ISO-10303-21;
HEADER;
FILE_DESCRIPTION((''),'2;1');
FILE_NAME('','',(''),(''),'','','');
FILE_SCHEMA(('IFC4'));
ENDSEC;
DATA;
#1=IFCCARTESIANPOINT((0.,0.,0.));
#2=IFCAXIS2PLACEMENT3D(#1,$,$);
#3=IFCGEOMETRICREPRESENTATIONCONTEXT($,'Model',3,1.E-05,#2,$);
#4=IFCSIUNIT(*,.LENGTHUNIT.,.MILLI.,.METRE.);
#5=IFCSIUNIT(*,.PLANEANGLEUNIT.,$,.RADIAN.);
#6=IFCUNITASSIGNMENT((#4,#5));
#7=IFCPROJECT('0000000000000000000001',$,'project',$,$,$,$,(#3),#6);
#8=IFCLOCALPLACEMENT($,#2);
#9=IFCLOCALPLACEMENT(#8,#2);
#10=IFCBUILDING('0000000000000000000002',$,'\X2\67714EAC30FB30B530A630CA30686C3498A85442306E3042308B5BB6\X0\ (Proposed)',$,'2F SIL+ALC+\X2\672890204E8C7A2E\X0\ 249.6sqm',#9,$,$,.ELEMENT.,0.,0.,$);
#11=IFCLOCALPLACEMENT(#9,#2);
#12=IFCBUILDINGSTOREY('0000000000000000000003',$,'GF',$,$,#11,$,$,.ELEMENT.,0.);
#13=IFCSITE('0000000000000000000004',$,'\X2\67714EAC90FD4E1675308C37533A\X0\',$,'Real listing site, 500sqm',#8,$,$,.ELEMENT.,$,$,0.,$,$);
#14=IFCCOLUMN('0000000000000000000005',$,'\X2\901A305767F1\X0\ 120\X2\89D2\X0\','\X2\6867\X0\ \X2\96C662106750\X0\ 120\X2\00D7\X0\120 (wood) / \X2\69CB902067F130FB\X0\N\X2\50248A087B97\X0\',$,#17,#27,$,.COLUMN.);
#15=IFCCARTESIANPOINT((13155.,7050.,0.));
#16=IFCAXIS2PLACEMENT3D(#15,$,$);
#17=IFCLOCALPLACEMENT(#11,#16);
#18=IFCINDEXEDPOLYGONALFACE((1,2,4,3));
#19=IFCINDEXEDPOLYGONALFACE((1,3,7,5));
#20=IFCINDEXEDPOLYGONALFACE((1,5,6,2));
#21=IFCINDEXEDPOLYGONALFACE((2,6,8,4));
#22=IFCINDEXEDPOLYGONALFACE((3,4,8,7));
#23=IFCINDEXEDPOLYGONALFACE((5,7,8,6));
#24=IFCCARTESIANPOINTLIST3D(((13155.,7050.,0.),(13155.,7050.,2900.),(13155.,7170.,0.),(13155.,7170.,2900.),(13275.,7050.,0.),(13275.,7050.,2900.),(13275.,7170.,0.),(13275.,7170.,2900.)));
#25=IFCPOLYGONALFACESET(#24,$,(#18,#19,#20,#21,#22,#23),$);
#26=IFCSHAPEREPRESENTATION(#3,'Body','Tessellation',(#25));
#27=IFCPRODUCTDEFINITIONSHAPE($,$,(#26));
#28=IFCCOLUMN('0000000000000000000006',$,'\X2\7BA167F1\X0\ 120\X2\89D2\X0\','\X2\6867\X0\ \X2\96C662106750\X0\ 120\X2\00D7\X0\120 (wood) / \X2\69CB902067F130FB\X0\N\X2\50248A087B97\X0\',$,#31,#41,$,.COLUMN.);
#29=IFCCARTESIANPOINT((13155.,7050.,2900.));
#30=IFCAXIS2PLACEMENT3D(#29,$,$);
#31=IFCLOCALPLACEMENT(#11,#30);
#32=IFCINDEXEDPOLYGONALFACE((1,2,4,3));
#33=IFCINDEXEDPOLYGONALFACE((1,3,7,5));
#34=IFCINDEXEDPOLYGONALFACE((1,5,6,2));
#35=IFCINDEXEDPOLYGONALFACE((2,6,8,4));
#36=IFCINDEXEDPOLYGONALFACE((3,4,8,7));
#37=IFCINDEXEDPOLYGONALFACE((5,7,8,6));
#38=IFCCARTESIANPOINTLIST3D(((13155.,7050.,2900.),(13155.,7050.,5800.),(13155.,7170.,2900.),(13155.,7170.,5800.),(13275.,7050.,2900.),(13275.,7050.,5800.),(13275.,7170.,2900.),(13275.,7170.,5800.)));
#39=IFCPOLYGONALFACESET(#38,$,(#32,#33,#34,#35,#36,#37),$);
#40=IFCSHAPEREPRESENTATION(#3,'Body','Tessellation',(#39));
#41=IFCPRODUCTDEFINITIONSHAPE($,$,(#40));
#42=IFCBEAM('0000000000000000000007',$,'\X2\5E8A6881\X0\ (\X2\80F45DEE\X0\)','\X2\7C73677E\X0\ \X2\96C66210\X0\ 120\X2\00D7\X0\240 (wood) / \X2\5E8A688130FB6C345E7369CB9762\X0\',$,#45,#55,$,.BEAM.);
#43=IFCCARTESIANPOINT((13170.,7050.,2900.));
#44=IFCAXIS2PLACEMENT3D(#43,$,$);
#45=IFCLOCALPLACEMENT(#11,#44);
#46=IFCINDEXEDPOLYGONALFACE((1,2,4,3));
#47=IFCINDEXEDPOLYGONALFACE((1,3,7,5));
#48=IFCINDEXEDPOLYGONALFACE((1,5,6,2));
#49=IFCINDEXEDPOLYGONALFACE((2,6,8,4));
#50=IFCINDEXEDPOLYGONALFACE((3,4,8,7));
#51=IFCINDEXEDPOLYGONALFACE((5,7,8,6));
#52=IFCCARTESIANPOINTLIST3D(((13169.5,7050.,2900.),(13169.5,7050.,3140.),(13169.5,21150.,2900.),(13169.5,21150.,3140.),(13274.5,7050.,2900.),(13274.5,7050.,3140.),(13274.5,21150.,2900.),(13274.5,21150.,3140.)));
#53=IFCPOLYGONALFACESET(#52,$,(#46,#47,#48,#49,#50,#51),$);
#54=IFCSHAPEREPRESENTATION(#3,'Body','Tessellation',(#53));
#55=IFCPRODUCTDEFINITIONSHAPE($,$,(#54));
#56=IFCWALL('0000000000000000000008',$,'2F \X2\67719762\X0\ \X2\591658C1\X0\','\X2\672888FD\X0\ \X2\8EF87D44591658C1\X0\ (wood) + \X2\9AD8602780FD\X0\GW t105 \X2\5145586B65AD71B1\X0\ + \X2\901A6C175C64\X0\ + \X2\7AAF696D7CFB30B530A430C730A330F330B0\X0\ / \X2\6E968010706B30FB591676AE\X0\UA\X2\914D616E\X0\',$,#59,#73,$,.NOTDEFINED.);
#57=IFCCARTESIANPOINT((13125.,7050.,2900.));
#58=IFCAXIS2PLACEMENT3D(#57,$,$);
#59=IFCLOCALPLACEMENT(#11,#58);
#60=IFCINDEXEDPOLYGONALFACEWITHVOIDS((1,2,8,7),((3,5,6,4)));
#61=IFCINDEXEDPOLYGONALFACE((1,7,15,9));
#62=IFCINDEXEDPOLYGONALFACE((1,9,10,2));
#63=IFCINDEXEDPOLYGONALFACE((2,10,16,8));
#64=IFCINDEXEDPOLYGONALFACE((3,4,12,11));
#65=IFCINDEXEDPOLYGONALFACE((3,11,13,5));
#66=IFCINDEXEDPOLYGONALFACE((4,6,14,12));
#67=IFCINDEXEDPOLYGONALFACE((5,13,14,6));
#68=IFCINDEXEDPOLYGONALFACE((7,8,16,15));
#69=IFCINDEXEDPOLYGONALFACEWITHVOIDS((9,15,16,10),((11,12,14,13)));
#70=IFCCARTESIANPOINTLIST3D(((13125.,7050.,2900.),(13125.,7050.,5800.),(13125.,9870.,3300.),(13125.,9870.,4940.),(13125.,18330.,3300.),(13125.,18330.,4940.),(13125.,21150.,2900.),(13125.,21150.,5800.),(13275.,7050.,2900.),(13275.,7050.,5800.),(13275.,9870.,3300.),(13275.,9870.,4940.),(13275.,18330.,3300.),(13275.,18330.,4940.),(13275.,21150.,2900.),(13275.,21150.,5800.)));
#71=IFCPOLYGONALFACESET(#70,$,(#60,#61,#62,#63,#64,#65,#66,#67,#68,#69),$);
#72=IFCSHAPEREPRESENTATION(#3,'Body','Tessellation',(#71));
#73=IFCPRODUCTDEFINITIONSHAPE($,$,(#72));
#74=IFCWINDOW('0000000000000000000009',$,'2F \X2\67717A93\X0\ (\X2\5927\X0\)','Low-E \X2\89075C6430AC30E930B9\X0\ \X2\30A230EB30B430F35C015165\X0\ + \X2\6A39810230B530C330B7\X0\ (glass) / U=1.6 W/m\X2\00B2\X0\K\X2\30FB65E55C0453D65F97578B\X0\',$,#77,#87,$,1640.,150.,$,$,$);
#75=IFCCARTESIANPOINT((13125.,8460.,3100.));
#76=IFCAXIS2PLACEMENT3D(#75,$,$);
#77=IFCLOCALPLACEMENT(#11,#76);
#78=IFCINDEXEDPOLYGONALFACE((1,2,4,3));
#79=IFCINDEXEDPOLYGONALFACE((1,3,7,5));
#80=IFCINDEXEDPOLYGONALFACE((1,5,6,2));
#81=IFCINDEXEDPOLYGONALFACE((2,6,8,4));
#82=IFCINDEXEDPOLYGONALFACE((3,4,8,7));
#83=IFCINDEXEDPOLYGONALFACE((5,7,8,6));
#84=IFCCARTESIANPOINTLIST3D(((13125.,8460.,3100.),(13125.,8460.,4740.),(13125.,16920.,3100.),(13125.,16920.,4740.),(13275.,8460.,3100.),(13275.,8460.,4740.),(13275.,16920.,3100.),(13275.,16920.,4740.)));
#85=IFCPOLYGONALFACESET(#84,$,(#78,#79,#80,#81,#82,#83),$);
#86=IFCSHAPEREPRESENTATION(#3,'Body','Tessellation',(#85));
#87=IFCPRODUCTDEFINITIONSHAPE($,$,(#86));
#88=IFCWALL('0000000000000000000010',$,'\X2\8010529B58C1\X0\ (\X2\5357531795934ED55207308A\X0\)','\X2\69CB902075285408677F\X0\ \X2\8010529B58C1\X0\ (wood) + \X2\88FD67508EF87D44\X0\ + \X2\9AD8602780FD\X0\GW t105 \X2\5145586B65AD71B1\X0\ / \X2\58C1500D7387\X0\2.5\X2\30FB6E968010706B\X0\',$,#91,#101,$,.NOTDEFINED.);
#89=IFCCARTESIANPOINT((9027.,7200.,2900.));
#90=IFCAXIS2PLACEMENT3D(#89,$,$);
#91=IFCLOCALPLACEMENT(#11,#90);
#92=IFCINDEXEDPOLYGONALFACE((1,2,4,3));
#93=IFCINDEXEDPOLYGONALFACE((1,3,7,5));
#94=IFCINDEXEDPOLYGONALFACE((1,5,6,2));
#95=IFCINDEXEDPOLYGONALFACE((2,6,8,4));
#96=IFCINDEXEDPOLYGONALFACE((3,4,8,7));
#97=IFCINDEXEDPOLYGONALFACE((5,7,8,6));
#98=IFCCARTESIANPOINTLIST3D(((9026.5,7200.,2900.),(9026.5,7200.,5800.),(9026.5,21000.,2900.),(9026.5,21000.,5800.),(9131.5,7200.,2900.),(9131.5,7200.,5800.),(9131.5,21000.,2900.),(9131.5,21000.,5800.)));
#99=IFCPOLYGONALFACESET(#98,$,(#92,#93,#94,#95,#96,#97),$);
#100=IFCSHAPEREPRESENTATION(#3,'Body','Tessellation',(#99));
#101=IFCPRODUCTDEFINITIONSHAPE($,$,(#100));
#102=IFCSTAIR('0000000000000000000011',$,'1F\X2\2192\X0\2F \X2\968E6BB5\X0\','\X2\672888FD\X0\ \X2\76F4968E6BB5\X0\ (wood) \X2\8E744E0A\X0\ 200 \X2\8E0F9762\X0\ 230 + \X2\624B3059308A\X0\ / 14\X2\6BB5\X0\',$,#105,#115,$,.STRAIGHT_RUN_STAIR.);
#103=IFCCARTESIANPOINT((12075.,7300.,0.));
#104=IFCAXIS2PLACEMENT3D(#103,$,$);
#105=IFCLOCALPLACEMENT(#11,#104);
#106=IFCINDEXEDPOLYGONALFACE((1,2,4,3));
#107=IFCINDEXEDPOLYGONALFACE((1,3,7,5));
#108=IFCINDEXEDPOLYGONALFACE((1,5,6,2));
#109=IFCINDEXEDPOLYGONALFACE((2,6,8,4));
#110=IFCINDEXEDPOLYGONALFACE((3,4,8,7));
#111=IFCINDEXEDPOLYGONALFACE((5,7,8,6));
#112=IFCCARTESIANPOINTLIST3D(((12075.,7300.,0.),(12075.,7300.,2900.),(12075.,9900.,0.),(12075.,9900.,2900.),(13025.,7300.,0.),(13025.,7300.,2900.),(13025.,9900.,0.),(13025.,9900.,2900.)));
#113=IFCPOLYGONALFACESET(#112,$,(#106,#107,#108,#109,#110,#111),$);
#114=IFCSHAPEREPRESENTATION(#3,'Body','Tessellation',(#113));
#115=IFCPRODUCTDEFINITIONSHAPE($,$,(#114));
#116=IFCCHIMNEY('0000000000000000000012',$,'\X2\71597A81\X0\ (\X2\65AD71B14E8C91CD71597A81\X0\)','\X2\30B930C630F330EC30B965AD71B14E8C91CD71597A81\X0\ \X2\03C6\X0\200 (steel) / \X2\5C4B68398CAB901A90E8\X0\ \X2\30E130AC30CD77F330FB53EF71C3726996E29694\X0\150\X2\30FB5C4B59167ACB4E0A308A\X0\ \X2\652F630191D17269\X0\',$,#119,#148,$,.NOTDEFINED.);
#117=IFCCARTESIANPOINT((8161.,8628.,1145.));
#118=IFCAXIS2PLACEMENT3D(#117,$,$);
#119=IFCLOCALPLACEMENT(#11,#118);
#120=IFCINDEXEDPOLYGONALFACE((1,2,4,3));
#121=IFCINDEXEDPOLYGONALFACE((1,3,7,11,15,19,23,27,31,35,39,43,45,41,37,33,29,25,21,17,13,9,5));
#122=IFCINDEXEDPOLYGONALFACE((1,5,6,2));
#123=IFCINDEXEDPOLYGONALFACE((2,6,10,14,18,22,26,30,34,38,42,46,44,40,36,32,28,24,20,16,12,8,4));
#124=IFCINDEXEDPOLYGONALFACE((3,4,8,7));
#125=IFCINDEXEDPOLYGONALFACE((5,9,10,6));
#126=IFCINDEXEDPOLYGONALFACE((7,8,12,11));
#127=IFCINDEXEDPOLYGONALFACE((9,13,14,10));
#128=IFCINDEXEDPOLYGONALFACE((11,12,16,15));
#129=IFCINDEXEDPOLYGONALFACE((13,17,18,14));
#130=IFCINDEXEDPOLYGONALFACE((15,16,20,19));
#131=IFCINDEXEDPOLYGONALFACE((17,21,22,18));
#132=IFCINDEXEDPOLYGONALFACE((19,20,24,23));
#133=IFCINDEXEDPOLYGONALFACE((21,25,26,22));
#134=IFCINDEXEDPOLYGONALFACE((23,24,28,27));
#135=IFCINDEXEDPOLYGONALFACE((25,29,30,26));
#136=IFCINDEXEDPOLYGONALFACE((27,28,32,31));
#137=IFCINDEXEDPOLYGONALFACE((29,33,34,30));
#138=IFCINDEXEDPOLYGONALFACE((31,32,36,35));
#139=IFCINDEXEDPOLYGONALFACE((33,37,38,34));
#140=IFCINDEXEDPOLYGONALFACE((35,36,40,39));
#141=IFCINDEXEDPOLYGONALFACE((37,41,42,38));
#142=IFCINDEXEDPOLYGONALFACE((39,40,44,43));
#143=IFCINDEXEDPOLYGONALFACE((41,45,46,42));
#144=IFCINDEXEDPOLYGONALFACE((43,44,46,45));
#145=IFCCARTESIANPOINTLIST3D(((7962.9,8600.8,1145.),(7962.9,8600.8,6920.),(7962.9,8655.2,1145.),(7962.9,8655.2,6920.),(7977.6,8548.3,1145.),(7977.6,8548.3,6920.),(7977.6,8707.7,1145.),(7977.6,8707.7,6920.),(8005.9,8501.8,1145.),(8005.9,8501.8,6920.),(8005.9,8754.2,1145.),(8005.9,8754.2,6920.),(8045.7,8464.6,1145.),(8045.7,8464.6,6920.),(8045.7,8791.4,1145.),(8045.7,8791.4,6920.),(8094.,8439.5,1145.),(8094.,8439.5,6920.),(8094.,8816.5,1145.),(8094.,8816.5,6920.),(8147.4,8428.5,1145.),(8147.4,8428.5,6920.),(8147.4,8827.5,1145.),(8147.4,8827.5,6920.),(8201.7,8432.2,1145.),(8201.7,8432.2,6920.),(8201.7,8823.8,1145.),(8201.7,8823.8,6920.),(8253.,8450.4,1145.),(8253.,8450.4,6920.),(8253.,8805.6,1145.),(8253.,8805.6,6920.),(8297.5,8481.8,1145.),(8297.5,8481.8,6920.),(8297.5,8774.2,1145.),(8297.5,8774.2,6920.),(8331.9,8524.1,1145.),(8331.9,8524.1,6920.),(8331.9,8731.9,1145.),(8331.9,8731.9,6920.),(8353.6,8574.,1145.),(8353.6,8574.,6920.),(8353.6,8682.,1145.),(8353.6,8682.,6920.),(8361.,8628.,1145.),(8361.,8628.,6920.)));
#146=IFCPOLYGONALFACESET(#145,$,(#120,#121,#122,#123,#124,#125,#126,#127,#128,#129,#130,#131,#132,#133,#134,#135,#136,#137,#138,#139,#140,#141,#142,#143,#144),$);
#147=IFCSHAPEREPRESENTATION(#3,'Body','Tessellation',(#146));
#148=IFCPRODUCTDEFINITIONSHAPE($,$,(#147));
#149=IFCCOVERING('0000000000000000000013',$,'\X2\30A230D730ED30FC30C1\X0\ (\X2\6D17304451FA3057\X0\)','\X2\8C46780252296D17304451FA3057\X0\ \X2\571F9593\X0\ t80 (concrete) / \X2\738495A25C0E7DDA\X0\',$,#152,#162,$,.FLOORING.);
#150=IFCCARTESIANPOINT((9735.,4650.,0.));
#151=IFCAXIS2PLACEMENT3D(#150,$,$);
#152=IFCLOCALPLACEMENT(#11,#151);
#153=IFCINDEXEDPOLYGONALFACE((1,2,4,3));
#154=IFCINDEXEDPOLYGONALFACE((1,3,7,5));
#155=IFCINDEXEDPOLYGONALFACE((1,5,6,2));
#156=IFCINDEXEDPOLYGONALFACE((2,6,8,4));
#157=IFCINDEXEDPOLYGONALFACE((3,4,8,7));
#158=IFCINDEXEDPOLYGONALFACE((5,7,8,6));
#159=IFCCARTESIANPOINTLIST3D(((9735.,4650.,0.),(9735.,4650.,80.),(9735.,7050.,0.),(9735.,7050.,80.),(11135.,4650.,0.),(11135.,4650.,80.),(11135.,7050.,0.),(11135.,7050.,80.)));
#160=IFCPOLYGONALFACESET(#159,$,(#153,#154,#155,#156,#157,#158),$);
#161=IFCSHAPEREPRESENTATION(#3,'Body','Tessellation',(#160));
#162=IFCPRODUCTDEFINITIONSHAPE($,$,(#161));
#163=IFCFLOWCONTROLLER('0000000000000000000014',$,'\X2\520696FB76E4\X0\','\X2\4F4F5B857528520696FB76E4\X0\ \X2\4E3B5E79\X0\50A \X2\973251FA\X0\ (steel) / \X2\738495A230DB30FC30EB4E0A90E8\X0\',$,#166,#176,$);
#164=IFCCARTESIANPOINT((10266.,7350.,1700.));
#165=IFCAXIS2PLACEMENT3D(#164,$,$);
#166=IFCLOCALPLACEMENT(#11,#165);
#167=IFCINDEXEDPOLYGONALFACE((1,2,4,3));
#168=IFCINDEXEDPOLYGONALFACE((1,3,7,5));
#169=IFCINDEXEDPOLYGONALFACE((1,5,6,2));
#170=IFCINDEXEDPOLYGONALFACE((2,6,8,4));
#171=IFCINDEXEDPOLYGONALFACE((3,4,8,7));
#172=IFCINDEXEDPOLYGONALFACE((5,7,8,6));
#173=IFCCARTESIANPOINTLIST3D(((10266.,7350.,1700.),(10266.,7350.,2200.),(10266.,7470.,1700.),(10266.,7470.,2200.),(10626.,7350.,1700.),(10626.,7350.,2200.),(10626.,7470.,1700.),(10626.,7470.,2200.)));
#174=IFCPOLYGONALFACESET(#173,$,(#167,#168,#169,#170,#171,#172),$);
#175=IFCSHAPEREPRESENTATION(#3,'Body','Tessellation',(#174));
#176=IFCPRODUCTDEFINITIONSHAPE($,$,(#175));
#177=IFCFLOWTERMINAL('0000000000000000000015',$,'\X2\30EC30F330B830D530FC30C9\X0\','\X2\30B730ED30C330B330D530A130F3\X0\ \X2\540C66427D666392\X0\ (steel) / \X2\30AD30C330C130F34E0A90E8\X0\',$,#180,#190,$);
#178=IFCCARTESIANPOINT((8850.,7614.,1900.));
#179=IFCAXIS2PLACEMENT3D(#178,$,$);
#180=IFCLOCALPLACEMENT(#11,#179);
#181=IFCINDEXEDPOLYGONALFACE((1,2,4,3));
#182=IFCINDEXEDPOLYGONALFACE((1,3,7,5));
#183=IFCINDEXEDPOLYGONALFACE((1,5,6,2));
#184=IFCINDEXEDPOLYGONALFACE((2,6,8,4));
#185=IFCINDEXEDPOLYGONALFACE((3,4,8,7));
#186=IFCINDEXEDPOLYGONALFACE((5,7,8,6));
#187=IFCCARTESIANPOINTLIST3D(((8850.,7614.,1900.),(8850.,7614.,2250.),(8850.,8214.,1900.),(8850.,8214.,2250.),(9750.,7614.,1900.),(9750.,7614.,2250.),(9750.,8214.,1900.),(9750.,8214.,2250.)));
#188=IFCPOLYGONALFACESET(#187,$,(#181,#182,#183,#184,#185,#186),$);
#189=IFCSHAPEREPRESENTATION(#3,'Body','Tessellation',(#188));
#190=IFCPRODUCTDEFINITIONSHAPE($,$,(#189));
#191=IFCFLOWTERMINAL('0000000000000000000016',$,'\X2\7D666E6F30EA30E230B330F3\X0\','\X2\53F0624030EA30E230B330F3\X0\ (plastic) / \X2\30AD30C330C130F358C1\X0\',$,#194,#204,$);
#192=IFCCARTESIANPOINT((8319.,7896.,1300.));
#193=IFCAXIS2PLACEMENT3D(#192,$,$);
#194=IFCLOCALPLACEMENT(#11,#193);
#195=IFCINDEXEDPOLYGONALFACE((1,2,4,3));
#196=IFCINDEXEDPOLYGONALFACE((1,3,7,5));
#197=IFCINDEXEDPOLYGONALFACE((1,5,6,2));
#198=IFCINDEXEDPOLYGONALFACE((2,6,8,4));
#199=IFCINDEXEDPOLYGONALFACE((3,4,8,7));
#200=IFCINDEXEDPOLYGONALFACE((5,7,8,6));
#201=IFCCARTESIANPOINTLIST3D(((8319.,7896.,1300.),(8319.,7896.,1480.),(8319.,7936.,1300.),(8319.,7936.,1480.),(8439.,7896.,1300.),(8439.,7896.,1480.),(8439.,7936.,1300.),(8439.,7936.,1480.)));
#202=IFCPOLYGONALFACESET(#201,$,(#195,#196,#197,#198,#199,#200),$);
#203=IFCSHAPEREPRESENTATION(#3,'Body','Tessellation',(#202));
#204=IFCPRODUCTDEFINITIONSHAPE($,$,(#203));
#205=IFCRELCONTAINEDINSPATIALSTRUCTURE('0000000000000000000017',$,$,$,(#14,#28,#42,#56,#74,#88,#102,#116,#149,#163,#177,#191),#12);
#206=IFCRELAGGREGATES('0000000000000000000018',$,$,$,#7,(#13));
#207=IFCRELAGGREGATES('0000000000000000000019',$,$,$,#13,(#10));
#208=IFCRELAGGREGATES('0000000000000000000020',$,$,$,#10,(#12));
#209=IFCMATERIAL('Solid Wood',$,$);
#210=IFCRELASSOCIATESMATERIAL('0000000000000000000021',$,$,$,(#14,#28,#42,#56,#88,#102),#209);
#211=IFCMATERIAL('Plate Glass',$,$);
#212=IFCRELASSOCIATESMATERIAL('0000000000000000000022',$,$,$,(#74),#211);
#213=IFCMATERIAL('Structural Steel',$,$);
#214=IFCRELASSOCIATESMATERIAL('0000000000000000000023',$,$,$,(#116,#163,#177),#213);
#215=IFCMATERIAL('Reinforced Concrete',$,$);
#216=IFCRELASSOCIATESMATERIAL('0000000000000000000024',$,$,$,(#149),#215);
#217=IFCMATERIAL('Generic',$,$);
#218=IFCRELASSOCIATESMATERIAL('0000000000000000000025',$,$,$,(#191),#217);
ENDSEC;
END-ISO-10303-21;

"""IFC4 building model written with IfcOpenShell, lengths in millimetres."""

from ifc_helpers import new_model, si_unit, frame, frame_2d, origin, origin_2d, place, context, project, spatial, rectangle, circle, extrude, material, element, fill, save


model = new_model("IFC4")

# Units and contexts
model_context = context("Model", 3, precision=1e-05, world=origin())
ifc_project = project(units=[si_unit("LENGTHUNIT", "METRE", prefix="MILLI"), si_unit("PLANEANGLEUNIT", "RADIAN")], contexts=[model_context])

# Site, building, storey
site_placement = place(None, origin())
site = spatial("IfcSite", under=ifc_project, at=site_placement, Name="東京都世田谷区", ObjectType="Real listing site, 500sqm", CompositionType="ELEMENT", RefElevation=0.0)
building_placement = place(site_placement, origin())
building = spatial("IfcBuilding", under=site, at=building_placement, Name="東京・サウナと水風呂のある家 (Proposed)", ObjectType="2F SIL+ALC+木造二種 249.6sqm", CompositionType="ELEMENT", ElevationOfRefHeight=0.0, ElevationOfTerrain=0.0)
storey_placement = place(building_placement, origin())
storey = spatial("IfcBuildingStorey", under=building, at=storey_placement, Name="GF", CompositionType="ELEMENT", Elevation=0.0)

# Columns
ifc_material_1 = material(Name="Solid Wood")
column_1_placement = place(storey_placement, frame((13155.0, 7050.0, 0.0)))
element("IfcColumn", 1, at=column_1_placement, inside=storey, material=ifc_material_1, Name="通し柱 120角", Description="桧 集成材 120×120 (wood) / 構造柱・N値計算", PredefinedType="COLUMN", context=model_context, shape_type="SweptSolid", body=[
    extrude(rectangle(XDim=120.0, YDim=120.0, at=frame_2d((60.0, 60.0))), frame((13155.0, 7050.0, 0.0)), (0.0, 0.0, 1.0), 2900.0),
])
column_2_placement = place(storey_placement, frame((13155.0, 7050.0, 2900.0)))
element("IfcColumn", 2, at=column_2_placement, inside=storey, material=ifc_material_1, Name="管柱 120角", Description="桧 集成材 120×120 (wood) / 構造柱・N値計算", PredefinedType="COLUMN", context=model_context, shape_type="SweptSolid", body=[
    extrude(rectangle(XDim=120.0, YDim=120.0, at=frame_2d((60.0, 60.0))), frame((13155.0, 7050.0, 2900.0)), (0.0, 0.0, 1.0), 2900.0),
])

# Beam
beam_1_placement = place(storey_placement, frame((13170.0, 7050.0, 2900.0)))
element("IfcBeam", 3, at=beam_1_placement, inside=storey, material=ifc_material_1, Name="床梁 (胴差)", Description="米松 集成 120×240 (wood) / 床梁・水平構面", PredefinedType="BEAM", context=model_context, shape_type="SweptSolid", body=[
    extrude(rectangle(XDim=105.0, YDim=14100.0, at=frame_2d((52.0, 7050.0))), frame((13170.0, 7050.0, 2900.0)), (0.0, 0.0, 1.0), 240.0),
])

# Shared definitions
ifc_material_2 = material(Name="Plate Glass")

# Wall, opening, window
wall_1_placement = place(storey_placement, frame((13125.0, 7050.0, 2900.0)))
wall_1 = element("IfcWall", 4, at=wall_1_placement, inside=storey, material=ifc_material_1, Name="2F 東面 外壁", Description="木製 軸組外壁 (wood) + 高性能GW t105 充填断熱 + 通気層 + 窯業系サイディング / 準耐火・外皮UA配慮", PredefinedType="NOTDEFINED", context=model_context, shape_type="SweptSolid", body=[
    extrude(rectangle(XDim=150.0, YDim=14100.0, at=frame_2d((75.0, 7050.0))), frame((13125.0, 7050.0, 2900.0)), (0.0, 0.0, 1.0), 2900.0),
])
opening_1_placement = place(storey_placement, frame((13125.0, 8460.0, 3100.0)))
opening_1 = element("IfcOpeningElement", 5, at=opening_1_placement, cuts=wall_1, PredefinedType="NOTDEFINED", context=model_context, shape_type="SweptSolid", body=[
    extrude(rectangle(XDim=150.0, YDim=8460.0, at=frame_2d((75.0, 4230.0))), frame((13125.0, 8460.0, 3100.0)), (0.0, 0.0, 1.0), 1640.0),
])
window_1_placement = place(storey_placement, frame((13125.0, 8460.0, 3100.0)))
window_1 = element("IfcWindow", 6, at=window_1_placement, inside=storey, material=ifc_material_2, Name="2F 東窓 (大)", Description="Low-E 複層ガラス アルゴン封入 + 樹脂サッシ (glass) / U=1.6 W/m²K・日射取得型", OverallHeight=1640.0, OverallWidth=150.0, context=model_context, shape_type="SweptSolid", body=[
    extrude(rectangle(XDim=150.0, YDim=8460.0, at=frame_2d((75.0, 4230.0))), frame((13125.0, 8460.0, 3100.0)), (0.0, 0.0, 1.0), 1640.0),
])
fill(opening_1, window_1)

# Wall
wall_2_placement = place(storey_placement, frame((9027.0, 7200.0, 2900.0)))
element("IfcWall", 7, at=wall_2_placement, inside=storey, material=ifc_material_1, Name="耐力壁 (南北間仕切り)", Description="構造用合板 耐力壁 (wood) + 製材軸組 + 高性能GW t105 充填断熱 / 壁倍率2.5・準耐火", PredefinedType="NOTDEFINED", context=model_context, shape_type="SweptSolid", body=[
    extrude(rectangle(XDim=105.0, YDim=13800.0, at=frame_2d((52.0, 6900.0))), frame((9027.0, 7200.0, 2900.0)), (0.0, 0.0, 1.0), 2900.0),
])

# Stair
stair_placement = place(storey_placement, frame((12075.0, 7300.0, 0.0)))
element("IfcStair", 8, at=stair_placement, inside=storey, material=ifc_material_1, Name="1F→2F 階段", Description="木製 直階段 (wood) 蹴上 200 踏面 230 + 手すり / 14段", PredefinedType="STRAIGHT_RUN_STAIR", context=model_context, shape_type="SweptSolid", body=[
    extrude(rectangle(XDim=950.0, YDim=2600.0, at=frame_2d((475.0, 1300.0))), frame((12075.0, 7300.0, 0.0)), (0.0, 0.0, 1.0), 2900.0),
])

# Chimney
ifc_material_3 = material(Name="Structural Steel")
chimney_placement = place(storey_placement, frame((8161.0, 8628.0, 1145.0)))
element("IfcChimney", 9, at=chimney_placement, inside=storey, material=ifc_material_3, Name="煙突 (断熱二重煙突)", Description="ステンレス断熱二重煙突 φ200 (steel) / 屋根貫通部 メガネ石・可燃物離隔150・屋外立上り 支持金物", PredefinedType="NOTDEFINED", context=model_context, shape_type="SweptSolid", body=[
    extrude(circle(Radius=200.0, at=origin_2d()), frame((8161.0, 8628.0, 1145.0)), (0.0, 0.0, 1.0), 5775.0),
])

# Covering
ifc_material_4 = material(Name="Reinforced Concrete")
covering_placement = place(storey_placement, frame((9735.0, 4650.0, 0.0)))
element("IfcCovering", 10, at=covering_placement, inside=storey, material=ifc_material_4, Name="アプローチ (洗い出し)", Description="豆砂利洗い出し 土間 t80 (concrete) / 玄関導線", PredefinedType="FLOORING", context=model_context, shape_type="SweptSolid", body=[
    extrude(rectangle(XDim=1400.0, YDim=2400.0, at=frame_2d((700.0, 1200.0))), frame((9735.0, 4650.0, 0.0)), (0.0, 0.0, 1.0), 80.0),
])

# Flow controller
flow_controller_placement = place(storey_placement, frame((10266.0, 7350.0, 1700.0)))
element("IfcFlowController", 11, at=flow_controller_placement, inside=storey, material=ifc_material_3, Name="分電盤", Description="住宅用分電盤 主幹50A 露出 (steel) / 玄関ホール上部", context=model_context, shape_type="SweptSolid", body=[
    extrude(rectangle(XDim=360.0, YDim=120.0, at=frame_2d((180.0, 60.0))), frame((10266.0, 7350.0, 1700.0)), (0.0, 0.0, 1.0), 500.0),
])

# Flow terminals
flow_terminal_1_placement = place(storey_placement, frame((8850.0, 7614.0, 1900.0)))
element("IfcFlowTerminal", 12, at=flow_terminal_1_placement, inside=storey, material=ifc_material_3, Name="レンジフード", Description="シロッコファン 同時給排 (steel) / キッチン上部", context=model_context, shape_type="SweptSolid", body=[
    extrude(rectangle(XDim=900.0, YDim=600.0, at=frame_2d((450.0, 300.0))), frame((8850.0, 7614.0, 1900.0)), (0.0, 0.0, 1.0), 350.0),
])
ifc_material_5 = material(Name="Generic")
flow_terminal_2_placement = place(storey_placement, frame((8319.0, 7896.0, 1300.0)))
element("IfcFlowTerminal", 13, at=flow_terminal_2_placement, inside=storey, material=ifc_material_5, Name="給湯リモコン", Description="台所リモコン (plastic) / キッチン壁", context=model_context, shape_type="SweptSolid", body=[
    extrude(rectangle(XDim=120.0, YDim=40.0, at=frame_2d((60.0, 20.0))), frame((8319.0, 7896.0, 1300.0)), (0.0, 0.0, 1.0), 180.0),
])

save(model, "model.ifc")
